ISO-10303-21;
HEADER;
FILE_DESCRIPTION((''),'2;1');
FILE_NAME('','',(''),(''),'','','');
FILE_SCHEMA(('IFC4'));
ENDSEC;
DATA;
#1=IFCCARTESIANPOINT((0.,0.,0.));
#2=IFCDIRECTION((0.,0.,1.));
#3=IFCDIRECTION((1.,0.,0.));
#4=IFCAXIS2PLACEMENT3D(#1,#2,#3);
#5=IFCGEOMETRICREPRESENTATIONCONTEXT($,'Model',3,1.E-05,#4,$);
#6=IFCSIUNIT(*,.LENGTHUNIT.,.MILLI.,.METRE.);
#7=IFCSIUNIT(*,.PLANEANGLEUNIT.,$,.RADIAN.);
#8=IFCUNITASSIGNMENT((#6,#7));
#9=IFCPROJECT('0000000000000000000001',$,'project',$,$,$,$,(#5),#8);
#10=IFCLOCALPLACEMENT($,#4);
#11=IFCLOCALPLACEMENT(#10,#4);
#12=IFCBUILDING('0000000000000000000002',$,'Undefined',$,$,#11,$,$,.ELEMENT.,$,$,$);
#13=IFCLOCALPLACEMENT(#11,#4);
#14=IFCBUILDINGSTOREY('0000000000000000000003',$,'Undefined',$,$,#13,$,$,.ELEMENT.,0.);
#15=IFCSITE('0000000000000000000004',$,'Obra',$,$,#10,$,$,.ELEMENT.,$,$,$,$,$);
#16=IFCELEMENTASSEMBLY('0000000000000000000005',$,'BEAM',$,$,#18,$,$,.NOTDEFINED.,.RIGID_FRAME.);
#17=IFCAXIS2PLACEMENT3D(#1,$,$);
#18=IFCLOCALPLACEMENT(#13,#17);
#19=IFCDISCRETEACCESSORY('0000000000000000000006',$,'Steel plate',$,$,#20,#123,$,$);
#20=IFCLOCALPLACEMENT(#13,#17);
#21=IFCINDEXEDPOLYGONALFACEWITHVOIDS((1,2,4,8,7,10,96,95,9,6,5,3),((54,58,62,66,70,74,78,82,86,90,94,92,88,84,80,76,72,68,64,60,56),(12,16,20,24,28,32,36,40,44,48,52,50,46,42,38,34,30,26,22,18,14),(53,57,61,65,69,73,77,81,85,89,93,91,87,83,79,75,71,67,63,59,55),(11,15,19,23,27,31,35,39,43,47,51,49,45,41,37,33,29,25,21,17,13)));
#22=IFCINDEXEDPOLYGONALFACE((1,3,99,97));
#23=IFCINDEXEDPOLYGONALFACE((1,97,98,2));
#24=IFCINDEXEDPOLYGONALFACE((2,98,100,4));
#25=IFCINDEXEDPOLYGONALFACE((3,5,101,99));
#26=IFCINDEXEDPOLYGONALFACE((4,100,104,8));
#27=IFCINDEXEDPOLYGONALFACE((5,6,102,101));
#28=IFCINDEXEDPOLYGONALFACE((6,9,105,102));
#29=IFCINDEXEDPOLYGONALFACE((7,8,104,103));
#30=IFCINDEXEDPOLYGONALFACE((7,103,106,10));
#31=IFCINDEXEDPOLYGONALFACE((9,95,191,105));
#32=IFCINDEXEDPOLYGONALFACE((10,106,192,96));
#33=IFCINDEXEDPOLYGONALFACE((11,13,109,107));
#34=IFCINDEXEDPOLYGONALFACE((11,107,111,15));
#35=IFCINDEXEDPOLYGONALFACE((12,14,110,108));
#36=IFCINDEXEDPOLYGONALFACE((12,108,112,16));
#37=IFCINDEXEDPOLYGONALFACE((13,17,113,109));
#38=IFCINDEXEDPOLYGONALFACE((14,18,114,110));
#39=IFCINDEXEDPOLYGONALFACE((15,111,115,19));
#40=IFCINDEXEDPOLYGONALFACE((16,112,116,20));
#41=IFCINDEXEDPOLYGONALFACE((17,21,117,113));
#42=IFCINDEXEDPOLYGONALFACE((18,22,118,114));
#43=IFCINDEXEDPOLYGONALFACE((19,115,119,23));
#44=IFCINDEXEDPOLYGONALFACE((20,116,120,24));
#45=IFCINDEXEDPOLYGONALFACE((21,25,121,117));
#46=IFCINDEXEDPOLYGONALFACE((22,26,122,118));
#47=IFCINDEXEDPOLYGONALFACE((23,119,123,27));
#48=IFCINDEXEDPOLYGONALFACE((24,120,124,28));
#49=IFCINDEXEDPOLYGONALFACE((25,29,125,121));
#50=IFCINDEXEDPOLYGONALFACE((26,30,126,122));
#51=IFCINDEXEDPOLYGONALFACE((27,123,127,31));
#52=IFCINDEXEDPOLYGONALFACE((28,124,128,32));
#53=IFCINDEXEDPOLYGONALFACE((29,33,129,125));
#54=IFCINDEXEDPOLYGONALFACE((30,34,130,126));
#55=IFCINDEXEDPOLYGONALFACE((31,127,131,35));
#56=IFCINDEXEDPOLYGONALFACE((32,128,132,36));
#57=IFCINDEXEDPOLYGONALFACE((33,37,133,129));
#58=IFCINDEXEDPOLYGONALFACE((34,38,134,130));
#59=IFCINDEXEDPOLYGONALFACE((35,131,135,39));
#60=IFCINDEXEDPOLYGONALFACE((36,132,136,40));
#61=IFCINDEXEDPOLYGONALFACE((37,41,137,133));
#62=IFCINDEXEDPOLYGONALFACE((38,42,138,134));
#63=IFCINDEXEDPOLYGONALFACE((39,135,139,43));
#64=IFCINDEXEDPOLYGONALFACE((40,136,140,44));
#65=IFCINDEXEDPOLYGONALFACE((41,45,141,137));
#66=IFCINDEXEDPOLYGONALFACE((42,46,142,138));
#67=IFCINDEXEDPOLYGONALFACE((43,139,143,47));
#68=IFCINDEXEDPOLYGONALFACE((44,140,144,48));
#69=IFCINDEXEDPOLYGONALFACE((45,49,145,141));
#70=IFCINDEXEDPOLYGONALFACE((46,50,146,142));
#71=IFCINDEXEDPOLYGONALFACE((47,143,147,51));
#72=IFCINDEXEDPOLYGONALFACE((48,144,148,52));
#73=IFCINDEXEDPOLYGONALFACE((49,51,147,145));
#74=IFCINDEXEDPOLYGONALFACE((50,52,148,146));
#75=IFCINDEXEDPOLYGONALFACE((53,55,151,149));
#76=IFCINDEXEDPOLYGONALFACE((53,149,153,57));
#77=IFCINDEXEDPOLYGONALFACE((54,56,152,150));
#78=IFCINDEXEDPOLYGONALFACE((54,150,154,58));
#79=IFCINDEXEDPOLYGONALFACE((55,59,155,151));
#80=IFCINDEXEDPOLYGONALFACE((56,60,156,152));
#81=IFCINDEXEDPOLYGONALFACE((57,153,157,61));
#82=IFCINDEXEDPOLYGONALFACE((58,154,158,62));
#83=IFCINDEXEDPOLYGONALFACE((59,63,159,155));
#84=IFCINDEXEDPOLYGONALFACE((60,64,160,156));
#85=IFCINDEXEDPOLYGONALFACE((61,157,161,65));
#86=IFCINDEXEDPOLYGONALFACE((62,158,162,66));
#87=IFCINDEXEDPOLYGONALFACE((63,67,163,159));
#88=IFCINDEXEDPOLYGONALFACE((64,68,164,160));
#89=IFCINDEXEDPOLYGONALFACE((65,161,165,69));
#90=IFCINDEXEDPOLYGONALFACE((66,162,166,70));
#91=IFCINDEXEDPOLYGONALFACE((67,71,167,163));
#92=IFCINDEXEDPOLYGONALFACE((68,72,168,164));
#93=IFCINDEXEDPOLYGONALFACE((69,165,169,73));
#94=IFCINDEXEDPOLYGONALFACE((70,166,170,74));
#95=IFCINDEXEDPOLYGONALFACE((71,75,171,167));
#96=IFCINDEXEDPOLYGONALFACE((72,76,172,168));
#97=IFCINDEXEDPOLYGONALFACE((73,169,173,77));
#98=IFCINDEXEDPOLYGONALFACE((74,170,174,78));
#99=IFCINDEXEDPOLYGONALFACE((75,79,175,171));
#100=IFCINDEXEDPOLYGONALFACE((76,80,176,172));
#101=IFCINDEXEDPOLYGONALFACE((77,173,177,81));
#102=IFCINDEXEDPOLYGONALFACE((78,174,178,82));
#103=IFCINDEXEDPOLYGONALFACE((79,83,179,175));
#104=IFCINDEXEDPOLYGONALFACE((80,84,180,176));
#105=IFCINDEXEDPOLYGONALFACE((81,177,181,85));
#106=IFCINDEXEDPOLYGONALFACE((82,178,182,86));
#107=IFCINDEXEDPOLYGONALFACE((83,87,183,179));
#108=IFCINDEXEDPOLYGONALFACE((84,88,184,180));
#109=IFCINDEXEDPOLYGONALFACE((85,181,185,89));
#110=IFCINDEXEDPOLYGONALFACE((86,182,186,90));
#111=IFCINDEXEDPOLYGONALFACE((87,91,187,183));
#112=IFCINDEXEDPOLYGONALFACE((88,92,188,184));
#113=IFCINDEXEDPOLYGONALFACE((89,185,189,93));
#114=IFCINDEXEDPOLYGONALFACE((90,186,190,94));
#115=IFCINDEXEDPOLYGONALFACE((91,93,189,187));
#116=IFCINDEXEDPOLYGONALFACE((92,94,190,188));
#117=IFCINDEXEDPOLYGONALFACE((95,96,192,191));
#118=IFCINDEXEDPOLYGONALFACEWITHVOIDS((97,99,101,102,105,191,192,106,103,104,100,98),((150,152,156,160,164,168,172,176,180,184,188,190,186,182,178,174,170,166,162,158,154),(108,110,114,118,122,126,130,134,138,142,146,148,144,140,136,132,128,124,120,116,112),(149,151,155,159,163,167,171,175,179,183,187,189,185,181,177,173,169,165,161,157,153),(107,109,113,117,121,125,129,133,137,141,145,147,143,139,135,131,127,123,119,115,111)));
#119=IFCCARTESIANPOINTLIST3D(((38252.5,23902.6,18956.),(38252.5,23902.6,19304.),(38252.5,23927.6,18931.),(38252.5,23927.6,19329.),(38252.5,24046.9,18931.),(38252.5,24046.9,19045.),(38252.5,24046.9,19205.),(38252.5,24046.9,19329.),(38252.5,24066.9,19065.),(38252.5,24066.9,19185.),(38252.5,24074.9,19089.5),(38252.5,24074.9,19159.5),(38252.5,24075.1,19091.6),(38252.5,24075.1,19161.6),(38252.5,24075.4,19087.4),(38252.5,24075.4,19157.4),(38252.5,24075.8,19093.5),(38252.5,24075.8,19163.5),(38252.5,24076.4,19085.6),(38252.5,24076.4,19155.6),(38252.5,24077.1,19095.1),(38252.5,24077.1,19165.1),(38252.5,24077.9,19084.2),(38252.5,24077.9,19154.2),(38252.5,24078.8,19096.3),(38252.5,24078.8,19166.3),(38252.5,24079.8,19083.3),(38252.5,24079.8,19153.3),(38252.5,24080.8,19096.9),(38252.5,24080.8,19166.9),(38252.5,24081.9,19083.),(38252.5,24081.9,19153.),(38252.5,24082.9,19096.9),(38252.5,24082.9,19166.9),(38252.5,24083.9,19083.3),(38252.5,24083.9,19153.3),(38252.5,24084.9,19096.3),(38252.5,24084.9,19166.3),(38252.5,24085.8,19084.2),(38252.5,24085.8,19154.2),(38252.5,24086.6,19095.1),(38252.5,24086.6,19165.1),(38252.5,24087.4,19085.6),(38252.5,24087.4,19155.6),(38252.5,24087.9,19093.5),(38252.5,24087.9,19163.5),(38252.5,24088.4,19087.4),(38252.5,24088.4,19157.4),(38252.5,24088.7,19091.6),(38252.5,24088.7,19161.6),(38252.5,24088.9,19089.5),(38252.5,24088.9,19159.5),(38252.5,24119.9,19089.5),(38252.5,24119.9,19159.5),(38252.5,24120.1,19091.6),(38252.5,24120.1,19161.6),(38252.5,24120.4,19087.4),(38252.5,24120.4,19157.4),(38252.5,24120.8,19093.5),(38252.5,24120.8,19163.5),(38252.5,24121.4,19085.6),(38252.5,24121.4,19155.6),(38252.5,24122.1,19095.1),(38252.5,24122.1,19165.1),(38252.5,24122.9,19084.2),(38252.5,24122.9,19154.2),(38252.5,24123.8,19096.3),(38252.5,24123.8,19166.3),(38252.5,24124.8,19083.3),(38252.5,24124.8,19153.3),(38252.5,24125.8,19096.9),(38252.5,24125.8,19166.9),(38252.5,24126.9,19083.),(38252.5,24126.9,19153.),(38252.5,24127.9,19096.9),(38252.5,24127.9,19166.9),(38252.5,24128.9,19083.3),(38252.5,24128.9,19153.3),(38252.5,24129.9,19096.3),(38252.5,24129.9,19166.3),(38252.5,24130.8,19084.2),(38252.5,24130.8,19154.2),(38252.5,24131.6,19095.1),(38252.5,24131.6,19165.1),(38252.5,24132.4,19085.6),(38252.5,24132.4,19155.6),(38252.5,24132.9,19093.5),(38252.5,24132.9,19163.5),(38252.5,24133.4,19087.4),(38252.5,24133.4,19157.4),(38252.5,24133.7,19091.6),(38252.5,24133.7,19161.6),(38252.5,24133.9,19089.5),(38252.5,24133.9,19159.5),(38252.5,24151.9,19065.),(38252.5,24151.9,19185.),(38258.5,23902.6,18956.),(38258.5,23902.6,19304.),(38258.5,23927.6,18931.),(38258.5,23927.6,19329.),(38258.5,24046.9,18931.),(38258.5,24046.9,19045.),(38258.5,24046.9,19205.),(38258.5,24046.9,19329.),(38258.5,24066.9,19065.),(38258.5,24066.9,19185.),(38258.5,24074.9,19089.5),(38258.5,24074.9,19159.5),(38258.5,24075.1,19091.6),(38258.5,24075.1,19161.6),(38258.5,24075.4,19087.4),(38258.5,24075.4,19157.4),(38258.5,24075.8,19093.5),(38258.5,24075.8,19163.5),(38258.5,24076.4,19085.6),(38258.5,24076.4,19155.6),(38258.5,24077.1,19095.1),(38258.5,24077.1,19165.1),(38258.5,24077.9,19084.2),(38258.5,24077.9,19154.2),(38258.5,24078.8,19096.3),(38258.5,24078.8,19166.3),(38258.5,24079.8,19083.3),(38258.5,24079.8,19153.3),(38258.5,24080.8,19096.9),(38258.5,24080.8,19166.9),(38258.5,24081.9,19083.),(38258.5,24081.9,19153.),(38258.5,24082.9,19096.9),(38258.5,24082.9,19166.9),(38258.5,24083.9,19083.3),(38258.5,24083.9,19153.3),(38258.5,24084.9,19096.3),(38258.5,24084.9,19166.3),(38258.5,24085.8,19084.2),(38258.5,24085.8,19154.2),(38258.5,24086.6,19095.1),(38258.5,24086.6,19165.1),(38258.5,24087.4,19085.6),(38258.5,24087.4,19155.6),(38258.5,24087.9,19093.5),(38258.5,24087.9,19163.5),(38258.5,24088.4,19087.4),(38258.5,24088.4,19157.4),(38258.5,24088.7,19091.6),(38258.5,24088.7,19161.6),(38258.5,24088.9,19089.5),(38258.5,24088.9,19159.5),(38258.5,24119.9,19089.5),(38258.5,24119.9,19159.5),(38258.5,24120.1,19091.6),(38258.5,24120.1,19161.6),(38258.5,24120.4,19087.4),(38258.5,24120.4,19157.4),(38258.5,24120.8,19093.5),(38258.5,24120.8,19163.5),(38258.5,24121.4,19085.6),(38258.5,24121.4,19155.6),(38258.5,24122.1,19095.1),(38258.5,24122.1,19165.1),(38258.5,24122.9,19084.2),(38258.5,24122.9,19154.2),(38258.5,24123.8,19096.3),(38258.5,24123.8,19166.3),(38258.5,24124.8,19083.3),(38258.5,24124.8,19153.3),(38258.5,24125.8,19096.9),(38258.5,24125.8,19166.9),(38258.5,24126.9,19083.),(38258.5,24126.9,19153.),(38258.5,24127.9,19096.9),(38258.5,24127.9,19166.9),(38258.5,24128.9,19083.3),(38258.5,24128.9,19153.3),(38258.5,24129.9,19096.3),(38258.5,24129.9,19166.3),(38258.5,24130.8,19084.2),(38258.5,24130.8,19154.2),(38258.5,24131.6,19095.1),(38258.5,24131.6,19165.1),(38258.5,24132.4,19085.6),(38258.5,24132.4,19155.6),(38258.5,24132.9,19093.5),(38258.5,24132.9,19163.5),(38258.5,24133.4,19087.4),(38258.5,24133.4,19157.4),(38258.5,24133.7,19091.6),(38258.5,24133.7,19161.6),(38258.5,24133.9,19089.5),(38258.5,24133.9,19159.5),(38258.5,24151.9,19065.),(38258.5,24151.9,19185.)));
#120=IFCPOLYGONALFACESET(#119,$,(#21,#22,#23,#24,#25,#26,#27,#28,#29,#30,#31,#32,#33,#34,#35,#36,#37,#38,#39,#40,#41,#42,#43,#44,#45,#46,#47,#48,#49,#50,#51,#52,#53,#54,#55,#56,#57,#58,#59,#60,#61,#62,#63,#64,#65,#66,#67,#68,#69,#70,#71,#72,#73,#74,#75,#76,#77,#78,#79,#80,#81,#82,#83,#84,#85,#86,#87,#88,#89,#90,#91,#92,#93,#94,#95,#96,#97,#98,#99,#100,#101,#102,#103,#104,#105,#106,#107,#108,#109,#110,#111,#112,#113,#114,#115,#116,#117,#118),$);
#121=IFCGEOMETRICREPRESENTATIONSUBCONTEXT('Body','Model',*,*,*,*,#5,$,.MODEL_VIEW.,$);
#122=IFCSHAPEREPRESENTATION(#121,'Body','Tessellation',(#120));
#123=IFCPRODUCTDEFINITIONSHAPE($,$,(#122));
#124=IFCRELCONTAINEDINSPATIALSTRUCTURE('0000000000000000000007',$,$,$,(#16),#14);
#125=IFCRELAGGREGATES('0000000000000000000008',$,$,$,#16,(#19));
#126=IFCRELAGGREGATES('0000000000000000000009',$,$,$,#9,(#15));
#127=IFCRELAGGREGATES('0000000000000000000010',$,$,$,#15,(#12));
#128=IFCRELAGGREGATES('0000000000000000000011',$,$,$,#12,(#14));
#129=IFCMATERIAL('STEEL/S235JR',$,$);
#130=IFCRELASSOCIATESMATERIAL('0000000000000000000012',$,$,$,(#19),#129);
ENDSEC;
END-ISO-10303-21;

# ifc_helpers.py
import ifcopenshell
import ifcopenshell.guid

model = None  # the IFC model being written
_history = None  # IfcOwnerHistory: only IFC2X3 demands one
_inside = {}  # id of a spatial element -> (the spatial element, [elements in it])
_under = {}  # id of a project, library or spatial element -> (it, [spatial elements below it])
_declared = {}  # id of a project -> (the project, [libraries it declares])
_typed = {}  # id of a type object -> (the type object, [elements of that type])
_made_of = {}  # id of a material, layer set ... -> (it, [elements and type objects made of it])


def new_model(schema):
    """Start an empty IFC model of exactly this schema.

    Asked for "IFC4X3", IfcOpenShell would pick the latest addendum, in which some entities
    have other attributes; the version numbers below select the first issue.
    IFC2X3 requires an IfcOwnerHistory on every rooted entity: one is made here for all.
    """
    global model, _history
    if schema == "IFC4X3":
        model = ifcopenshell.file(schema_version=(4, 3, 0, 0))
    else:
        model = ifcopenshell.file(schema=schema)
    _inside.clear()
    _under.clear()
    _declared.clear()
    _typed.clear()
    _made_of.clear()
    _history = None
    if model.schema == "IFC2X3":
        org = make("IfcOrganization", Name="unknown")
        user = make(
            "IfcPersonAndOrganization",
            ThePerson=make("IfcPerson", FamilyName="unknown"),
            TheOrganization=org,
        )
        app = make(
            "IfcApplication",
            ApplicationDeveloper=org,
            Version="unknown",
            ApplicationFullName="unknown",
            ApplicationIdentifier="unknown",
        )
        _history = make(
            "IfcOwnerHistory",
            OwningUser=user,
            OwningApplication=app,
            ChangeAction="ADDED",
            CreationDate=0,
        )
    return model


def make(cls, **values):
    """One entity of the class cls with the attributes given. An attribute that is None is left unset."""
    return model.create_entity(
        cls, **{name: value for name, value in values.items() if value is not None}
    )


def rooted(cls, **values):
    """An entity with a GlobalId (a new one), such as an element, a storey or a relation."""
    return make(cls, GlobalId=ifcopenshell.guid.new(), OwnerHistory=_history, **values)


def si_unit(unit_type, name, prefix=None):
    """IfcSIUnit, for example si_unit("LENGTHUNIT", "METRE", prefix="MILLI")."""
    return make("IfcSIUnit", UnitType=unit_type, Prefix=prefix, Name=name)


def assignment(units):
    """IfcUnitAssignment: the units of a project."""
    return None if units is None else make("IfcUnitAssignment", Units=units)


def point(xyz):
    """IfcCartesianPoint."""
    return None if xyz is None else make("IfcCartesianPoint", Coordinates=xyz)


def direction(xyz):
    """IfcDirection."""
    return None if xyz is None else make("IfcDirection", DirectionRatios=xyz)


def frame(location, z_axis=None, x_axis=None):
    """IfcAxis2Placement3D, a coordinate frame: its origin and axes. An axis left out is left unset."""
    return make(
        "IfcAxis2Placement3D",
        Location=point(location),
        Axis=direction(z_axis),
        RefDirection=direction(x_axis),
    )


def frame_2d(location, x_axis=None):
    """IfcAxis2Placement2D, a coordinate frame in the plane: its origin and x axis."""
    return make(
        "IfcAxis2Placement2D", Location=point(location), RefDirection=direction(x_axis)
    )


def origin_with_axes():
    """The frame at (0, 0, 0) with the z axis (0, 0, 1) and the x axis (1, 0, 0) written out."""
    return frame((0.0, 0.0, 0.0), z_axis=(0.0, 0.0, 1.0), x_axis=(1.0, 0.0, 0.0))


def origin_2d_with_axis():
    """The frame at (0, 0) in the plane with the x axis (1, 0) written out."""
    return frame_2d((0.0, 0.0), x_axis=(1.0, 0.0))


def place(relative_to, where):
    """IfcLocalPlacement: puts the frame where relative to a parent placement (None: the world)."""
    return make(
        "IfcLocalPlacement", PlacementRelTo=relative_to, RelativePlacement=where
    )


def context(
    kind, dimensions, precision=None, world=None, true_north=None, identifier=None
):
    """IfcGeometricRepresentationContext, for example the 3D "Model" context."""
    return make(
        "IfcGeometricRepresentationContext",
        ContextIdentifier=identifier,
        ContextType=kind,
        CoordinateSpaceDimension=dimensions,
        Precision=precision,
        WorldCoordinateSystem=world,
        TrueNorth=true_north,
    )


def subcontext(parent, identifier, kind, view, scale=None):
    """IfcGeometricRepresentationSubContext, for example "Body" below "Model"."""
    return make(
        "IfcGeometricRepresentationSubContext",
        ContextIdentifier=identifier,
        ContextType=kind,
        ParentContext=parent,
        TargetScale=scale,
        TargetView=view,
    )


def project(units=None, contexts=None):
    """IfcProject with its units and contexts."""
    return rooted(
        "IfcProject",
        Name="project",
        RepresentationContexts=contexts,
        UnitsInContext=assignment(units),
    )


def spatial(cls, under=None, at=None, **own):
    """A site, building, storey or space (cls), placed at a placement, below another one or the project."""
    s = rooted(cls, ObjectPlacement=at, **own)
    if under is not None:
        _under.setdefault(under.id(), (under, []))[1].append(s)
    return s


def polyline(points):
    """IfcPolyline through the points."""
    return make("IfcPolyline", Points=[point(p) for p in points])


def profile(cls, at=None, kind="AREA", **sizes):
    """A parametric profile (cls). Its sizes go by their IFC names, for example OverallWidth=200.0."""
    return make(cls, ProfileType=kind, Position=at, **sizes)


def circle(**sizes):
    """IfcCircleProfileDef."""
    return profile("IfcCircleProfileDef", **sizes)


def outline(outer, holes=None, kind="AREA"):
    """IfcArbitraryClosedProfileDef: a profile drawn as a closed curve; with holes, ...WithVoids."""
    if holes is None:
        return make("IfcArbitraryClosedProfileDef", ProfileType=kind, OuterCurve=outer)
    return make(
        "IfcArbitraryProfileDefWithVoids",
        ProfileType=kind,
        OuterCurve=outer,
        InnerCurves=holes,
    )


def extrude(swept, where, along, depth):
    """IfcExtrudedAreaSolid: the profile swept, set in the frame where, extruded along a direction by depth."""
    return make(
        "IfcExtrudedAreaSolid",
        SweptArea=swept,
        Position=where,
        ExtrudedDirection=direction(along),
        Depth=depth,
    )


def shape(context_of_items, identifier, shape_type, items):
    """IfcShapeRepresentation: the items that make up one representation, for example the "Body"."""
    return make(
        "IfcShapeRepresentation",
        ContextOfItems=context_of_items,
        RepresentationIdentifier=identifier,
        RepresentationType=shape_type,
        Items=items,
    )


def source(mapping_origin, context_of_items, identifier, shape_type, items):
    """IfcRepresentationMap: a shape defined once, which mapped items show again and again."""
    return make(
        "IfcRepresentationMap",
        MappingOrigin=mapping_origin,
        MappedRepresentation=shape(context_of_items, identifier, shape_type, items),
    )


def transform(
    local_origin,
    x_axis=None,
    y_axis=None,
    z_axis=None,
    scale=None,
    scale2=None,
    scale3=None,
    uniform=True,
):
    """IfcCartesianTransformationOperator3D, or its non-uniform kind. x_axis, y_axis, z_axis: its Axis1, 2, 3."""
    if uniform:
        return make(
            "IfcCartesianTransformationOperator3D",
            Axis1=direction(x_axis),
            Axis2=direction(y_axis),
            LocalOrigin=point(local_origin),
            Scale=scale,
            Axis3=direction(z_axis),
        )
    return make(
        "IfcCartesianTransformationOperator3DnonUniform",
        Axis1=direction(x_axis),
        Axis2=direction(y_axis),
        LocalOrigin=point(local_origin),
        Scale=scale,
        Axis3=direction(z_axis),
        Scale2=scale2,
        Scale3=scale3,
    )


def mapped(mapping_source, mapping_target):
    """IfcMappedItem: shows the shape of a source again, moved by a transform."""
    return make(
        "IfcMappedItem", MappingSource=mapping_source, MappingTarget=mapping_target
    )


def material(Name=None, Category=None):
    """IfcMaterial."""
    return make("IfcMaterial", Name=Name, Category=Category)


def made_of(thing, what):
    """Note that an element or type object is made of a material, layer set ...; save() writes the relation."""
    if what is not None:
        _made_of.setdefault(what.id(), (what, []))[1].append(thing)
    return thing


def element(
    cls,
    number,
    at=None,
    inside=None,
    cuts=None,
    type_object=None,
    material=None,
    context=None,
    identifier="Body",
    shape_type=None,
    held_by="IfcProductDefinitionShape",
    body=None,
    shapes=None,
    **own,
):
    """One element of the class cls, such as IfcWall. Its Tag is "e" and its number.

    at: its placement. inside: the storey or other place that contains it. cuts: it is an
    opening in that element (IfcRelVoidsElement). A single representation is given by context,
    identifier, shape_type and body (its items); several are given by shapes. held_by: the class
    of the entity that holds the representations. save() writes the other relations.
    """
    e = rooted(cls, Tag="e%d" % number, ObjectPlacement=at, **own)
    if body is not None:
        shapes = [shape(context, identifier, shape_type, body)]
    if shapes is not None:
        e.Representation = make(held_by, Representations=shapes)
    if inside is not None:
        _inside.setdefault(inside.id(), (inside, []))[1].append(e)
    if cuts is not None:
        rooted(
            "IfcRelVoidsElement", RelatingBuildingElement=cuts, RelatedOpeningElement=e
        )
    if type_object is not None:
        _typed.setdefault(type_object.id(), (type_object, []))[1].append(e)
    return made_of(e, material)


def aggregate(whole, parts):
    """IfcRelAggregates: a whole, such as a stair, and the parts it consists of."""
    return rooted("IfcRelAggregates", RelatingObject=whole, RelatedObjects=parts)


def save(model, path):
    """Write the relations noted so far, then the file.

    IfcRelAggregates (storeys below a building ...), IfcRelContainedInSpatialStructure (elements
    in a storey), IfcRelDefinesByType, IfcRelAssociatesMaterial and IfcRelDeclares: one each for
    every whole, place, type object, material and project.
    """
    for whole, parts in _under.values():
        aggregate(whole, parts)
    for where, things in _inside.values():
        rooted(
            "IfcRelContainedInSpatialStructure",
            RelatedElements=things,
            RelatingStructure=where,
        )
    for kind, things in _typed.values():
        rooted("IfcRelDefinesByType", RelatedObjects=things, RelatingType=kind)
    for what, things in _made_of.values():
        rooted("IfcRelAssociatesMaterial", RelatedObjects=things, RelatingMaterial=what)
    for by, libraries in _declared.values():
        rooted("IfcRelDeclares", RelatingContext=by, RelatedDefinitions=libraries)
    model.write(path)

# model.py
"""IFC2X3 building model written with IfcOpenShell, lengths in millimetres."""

from ifc_helpers import new_model, si_unit, frame, origin_with_axes, origin_2d_with_axis, place, context, subcontext, project, spatial, polyline, circle, outline, extrude, source, transform, mapped, material, element, aggregate, save


model = new_model("IFC2X3")

# Units and contexts
model_context = context("Model", 3, precision=1e-05, world=origin_with_axes())
body_context = subcontext(model_context, "Body", "Model", "MODEL_VIEW")
ifc_project = project(units=[si_unit("LENGTHUNIT", "METRE", prefix="MILLI"), si_unit("PLANEANGLEUNIT", "RADIAN")], contexts=[model_context])

# Site, building, storey
site_placement = place(None, origin_with_axes())
site = spatial("IfcSite", under=ifc_project, at=site_placement, Name="Obra", CompositionType="ELEMENT")
building_placement = place(site_placement, origin_with_axes())
building = spatial("IfcBuilding", under=site, at=building_placement, Name="Undefined", CompositionType="ELEMENT")
storey_placement = place(building_placement, origin_with_axes())
storey = spatial("IfcBuildingStorey", under=building, at=storey_placement, Name="Undefined", CompositionType="ELEMENT", Elevation=0.0)

# Shared definitions
ifc_material_1 = material(Name="STEEL/S235JR")

# Element assembly
assembly_1_placement = place(storey_placement, origin_with_axes())
assembly_1 = element("IfcElementAssembly", 1, at=assembly_1_placement, inside=storey, Name="BEAM", AssemblyPlace="NOTDEFINED", PredefinedType="RIGID_FRAME")

# Discrete accessory, opening
discrete_accessory_1_placement = place(assembly_1_placement, frame((38255.5, 23902.6, 18956.0), z_axis=(1.0, 0.0, 0.0), x_axis=(0.0, 0.707107, -0.707107)))
discrete_accessory_1 = element("IfcDiscreteAccessory", 2, at=discrete_accessory_1_placement, material=ifc_material_1, Name="Steel plate", context=body_context, shape_type="SweptSolid", body=[
    extrude(outline(polyline([(0.0, 0.0), (35.4, 0.0), (119.7, 84.3), (39.1, 164.9), (39.1, 193.2), (99.2, 253.3), (14.3, 338.2), (-45.8, 278.1), (-74.1, 278.1), (-161.8, 365.8), (-246.1, 281.4), (-246.1, 246.1), (0.0, 0.0)])), frame((0.0, 0.0, -3.0), z_axis=(0.0, 0.0, 1.0), x_axis=(1.0, 0.0, 0.0)), (0.0, 0.0, 1.0), 6.0),
])
shared_shape_1 = source(origin_with_axes(), body_context, "Body", "SweptSolid", [
    extrude(circle(Radius=7.0, at=origin_2d_with_axis()), frame((0.0, -8.6, 0.0), z_axis=(0.0, 1.0, 0.0), x_axis=(1.0, 0.0, 0.0)), (0.0, 0.0, 1.0), 6.2),
])
opening_1_placement = place(assembly_1_placement, frame((38250.0, 24056.9, 19185.0), z_axis=(0.0, 1.0, 0.0), x_axis=(0.0, 0.0, -1.0)))
element("IfcOpeningElement", 3, at=opening_1_placement, cuts=discrete_accessory_1, ObjectType="Opening", context=body_context, shape_type="MappedRepresentation", body=[
    mapped(shared_shape_1, transform((25.0, 0.0, 25.0))),
    mapped(shared_shape_1, transform((25.0, 0.0, 70.0))),
    mapped(shared_shape_1, transform((95.0, 0.0, 25.0))),
    mapped(shared_shape_1, transform((95.0, 0.0, 70.0))),
])

aggregate(assembly_1, [discrete_accessory_1])

save(model, "model.ifc")
